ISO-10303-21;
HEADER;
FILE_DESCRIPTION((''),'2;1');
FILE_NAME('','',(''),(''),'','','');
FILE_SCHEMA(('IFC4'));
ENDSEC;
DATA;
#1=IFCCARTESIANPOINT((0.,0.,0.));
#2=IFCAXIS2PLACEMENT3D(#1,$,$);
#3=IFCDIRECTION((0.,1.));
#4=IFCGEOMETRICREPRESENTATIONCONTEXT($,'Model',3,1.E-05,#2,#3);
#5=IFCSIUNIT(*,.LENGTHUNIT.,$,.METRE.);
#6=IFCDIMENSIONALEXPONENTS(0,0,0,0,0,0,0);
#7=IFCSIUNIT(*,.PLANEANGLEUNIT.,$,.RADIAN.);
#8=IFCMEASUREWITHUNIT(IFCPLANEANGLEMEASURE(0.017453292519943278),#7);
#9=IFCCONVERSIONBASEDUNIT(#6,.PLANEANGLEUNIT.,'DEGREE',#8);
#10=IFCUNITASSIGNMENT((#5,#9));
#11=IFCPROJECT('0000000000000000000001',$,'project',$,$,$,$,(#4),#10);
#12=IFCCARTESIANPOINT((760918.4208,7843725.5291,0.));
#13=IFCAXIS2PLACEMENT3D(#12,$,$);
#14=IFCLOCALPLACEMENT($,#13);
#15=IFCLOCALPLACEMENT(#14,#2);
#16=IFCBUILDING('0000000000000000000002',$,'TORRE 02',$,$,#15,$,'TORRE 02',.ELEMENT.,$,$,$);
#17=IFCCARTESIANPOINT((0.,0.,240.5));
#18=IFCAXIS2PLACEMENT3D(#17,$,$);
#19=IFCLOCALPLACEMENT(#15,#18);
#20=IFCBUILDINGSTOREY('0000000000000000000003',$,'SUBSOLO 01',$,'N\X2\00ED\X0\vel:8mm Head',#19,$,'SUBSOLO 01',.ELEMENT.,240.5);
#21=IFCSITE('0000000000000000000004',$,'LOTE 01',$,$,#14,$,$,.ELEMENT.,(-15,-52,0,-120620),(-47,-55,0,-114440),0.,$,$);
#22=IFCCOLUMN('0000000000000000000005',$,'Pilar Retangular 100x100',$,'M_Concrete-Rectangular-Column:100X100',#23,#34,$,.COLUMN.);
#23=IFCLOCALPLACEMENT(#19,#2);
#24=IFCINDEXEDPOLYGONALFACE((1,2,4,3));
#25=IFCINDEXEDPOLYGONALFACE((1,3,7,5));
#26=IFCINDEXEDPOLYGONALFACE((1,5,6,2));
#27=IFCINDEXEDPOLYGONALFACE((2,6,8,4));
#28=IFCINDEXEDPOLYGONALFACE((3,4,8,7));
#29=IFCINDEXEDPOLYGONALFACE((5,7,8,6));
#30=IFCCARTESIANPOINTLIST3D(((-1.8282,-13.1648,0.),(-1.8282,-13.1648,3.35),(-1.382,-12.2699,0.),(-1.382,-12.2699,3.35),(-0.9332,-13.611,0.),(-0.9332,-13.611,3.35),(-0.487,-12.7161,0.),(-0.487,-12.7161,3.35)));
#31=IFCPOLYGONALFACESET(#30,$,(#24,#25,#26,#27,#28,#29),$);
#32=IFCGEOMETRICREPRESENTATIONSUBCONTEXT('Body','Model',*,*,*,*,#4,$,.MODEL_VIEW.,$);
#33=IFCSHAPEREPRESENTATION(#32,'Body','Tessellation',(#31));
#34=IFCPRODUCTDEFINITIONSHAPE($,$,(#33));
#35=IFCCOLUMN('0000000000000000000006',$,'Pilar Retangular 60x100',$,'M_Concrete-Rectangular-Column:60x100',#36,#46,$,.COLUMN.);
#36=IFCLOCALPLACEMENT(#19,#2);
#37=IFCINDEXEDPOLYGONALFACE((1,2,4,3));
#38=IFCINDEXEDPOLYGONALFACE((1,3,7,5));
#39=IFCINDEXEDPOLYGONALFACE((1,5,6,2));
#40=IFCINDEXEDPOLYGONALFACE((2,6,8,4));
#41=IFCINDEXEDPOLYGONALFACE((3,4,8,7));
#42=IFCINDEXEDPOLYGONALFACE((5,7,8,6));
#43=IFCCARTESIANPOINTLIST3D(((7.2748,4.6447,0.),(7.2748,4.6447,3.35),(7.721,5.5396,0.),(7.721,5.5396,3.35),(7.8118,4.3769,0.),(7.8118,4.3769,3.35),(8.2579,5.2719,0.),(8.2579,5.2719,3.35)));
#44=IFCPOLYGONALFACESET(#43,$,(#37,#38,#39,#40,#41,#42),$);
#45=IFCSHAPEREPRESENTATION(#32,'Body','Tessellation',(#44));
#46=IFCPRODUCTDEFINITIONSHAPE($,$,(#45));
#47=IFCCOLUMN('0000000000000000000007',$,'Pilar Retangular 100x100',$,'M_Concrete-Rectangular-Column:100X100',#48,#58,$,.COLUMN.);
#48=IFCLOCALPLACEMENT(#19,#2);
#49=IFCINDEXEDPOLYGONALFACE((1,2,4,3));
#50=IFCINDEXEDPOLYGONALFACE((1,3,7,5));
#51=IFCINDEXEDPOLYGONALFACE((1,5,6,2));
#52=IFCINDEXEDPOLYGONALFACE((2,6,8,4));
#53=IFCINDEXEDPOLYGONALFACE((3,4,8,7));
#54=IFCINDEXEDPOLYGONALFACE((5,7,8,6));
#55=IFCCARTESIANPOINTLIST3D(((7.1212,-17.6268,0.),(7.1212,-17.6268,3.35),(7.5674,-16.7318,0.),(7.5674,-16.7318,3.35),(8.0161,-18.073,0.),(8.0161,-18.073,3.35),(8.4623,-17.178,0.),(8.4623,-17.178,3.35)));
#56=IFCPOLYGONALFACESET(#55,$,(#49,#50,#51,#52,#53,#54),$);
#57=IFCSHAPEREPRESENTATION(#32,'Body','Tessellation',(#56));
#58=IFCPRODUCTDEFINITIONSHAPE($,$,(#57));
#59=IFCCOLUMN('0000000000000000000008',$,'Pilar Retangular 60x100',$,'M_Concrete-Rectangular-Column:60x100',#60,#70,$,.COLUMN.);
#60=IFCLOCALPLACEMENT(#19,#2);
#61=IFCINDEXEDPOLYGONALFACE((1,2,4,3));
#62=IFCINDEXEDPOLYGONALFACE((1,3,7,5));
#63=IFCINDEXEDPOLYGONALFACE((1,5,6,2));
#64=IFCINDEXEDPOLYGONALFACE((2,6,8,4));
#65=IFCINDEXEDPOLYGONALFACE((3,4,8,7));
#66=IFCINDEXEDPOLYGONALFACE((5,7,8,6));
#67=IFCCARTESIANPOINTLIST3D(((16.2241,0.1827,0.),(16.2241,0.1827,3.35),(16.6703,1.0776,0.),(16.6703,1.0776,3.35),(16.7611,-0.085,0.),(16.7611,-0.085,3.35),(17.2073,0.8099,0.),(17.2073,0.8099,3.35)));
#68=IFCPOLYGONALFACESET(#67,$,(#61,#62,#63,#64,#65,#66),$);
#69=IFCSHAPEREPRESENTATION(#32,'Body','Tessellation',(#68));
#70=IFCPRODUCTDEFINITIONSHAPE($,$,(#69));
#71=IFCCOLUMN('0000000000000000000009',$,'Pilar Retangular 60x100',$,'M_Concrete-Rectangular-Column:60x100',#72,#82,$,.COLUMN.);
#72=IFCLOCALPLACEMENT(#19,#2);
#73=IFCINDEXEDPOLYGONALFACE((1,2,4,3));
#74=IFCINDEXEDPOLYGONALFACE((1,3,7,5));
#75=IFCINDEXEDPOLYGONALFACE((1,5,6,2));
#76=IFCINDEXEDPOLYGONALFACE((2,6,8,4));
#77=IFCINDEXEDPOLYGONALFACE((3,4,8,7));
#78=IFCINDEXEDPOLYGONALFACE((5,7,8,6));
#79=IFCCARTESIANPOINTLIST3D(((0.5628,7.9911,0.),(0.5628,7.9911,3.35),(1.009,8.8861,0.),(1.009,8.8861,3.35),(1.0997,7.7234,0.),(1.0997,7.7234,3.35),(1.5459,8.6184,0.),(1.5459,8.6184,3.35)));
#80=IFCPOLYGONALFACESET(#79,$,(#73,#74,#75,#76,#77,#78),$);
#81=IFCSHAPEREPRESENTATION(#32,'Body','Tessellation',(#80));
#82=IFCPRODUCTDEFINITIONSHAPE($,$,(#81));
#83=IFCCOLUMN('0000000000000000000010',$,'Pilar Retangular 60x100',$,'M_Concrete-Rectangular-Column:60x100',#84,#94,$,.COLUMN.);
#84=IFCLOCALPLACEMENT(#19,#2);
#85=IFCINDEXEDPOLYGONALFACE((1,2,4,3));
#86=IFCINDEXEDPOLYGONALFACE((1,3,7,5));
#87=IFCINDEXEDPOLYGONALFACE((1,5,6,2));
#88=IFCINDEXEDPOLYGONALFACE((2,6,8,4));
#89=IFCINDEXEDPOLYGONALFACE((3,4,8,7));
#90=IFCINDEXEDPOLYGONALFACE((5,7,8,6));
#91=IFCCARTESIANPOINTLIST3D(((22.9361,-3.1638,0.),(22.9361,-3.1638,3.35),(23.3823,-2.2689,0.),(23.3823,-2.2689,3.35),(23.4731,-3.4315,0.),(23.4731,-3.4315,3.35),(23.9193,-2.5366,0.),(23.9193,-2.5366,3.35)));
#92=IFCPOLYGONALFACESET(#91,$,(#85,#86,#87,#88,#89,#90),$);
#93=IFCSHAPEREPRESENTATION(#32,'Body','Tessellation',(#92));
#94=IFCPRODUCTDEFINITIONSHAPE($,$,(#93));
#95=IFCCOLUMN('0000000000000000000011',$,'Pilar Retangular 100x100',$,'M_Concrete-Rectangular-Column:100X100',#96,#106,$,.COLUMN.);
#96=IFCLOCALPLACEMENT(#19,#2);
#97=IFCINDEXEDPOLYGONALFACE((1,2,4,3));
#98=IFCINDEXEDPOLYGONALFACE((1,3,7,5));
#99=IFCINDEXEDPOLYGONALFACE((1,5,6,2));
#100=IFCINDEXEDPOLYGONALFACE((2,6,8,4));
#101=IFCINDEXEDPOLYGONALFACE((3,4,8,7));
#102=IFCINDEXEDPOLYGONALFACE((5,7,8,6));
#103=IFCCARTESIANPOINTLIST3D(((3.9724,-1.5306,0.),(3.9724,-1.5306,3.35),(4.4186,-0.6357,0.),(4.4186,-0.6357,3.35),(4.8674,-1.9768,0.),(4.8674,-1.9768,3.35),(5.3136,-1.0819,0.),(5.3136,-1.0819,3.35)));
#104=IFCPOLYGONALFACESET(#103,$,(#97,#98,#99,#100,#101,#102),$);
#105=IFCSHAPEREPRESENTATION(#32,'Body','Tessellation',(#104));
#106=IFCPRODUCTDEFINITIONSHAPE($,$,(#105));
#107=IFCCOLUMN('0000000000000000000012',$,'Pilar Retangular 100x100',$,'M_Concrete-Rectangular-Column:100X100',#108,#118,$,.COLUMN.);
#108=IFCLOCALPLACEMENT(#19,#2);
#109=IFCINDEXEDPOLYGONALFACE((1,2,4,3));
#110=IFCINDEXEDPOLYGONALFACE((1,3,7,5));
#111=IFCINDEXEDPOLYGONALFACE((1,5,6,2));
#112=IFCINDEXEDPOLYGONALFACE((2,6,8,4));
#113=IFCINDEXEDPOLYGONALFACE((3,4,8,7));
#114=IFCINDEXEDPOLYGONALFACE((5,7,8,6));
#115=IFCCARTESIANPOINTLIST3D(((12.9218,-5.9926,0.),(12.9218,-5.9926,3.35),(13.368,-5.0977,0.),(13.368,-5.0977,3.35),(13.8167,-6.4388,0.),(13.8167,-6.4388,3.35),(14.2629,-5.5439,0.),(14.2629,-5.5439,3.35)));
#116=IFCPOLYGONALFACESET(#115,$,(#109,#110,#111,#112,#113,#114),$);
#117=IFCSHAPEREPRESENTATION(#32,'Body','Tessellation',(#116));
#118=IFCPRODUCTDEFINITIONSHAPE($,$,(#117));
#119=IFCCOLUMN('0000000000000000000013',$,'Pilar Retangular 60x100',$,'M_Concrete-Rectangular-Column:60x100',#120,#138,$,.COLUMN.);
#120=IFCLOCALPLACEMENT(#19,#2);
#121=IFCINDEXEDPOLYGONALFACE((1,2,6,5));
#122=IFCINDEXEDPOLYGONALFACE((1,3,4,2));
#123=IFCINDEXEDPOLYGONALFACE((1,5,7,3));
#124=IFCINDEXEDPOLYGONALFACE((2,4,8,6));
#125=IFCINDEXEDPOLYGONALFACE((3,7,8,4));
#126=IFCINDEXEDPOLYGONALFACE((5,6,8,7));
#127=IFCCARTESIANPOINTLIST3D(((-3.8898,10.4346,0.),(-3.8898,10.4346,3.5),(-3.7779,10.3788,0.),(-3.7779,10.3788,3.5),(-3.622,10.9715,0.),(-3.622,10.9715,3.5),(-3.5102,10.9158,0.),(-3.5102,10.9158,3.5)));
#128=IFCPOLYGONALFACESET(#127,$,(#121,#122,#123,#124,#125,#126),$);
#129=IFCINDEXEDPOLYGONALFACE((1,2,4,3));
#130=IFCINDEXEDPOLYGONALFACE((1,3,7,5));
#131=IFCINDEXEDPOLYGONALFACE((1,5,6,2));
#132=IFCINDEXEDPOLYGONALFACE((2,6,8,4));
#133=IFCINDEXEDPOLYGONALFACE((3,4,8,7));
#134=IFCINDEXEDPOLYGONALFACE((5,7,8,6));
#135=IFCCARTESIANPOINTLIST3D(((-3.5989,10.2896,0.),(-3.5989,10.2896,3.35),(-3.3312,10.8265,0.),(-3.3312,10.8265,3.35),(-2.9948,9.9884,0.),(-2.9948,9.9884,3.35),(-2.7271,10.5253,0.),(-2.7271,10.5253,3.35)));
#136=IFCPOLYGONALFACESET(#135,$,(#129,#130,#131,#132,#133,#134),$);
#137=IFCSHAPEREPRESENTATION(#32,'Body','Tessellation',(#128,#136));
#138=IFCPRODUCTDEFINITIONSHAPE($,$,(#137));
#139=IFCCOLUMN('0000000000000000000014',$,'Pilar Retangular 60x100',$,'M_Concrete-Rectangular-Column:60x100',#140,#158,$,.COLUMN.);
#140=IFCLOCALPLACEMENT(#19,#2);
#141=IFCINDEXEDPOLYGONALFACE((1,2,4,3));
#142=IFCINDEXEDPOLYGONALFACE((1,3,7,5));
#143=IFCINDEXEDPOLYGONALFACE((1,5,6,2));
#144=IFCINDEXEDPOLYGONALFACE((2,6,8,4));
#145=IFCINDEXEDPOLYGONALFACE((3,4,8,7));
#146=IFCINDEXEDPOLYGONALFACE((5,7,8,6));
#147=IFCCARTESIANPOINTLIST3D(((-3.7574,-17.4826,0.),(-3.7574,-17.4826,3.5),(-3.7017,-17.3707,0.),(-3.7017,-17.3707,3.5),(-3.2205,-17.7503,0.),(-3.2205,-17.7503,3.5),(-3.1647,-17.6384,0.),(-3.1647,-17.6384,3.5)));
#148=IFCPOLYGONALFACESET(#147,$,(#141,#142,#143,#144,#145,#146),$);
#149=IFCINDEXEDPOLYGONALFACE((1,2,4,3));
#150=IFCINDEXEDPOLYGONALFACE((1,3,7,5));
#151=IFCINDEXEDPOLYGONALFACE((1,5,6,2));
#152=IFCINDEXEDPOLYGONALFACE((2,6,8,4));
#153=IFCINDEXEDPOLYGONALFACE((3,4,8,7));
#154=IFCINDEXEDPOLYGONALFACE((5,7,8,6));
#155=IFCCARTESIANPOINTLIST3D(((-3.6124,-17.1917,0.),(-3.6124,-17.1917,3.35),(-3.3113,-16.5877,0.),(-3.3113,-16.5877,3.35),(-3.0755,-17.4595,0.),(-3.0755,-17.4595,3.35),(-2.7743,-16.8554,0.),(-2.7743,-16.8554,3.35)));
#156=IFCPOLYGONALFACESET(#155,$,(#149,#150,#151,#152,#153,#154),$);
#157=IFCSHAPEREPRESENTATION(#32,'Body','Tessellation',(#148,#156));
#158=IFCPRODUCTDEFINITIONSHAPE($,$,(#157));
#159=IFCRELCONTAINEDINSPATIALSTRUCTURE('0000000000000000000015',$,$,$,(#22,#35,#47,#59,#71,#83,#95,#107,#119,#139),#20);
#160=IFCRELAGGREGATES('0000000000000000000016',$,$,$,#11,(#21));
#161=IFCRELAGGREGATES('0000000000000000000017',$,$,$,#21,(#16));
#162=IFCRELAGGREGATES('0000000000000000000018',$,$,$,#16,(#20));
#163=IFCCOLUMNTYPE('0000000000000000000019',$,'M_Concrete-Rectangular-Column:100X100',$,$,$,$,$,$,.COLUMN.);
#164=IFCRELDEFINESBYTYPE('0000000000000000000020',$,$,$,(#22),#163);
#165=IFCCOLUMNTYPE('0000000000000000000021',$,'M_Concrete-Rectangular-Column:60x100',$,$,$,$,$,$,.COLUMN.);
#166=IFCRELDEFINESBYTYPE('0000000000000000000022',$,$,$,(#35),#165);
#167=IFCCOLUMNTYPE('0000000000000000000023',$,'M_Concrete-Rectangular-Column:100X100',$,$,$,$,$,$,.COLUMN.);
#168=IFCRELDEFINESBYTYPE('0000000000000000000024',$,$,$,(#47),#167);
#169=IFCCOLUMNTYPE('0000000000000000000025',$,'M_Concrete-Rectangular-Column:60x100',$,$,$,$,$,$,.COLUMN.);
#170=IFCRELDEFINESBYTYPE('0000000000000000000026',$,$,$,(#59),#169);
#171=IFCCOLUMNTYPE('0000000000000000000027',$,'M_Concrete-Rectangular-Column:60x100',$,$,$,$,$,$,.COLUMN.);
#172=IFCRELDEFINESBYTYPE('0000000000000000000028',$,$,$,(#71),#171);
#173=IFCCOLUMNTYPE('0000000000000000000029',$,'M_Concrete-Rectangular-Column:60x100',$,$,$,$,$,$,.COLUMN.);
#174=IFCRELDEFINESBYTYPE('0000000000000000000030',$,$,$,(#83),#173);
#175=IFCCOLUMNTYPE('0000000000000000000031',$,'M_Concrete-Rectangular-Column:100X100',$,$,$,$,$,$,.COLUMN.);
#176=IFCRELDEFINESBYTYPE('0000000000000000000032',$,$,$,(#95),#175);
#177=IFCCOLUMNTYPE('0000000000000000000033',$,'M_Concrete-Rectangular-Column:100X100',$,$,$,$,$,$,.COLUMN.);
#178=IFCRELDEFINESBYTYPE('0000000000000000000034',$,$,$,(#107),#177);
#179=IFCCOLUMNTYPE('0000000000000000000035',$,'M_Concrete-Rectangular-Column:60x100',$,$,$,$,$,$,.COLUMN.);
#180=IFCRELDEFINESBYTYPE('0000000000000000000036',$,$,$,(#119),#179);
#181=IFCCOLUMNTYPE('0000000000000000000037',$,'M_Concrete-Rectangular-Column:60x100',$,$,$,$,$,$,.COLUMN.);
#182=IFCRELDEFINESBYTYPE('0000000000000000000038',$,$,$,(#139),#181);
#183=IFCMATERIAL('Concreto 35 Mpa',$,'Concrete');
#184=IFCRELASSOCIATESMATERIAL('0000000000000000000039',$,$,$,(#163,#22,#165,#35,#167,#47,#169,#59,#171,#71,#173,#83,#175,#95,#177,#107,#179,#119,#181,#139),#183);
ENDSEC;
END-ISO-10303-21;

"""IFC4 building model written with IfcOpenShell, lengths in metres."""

from ifc_helpers import new_model, entity, si_unit, converted_unit, direction, frame, origin, place, context, subcontext, project, spatial, indexed_curve, outline, extrude, source, transform, mapped, material, type_object, type_shapes, element, save


model = new_model("IFC4")

# Units and contexts
model_context = context("Model", 3, precision=1e-05, world=origin(), true_north=direction((0.0, 1.0)))
body_context = subcontext(model_context, "Body", "Model", "MODEL_VIEW")
ifc_project = project(units=[si_unit("LENGTHUNIT", "METRE"), converted_unit("PLANEANGLEUNIT", "DEGREE", entity("IfcPlaneAngleMeasure", 0.017453292519943278), si_unit("PLANEANGLEUNIT", "RADIAN"), dimensions=[0, 0, 0, 0, 0, 0, 0])], contexts=[model_context])

# Site, building, storey
site_placement = place(None, frame((760918.4208, 7843725.5291, 0.0)))
site = spatial("IfcSite", under=ifc_project, at=site_placement, Name="LOTE 01", CompositionType="ELEMENT", RefLatitude=(-15, -52, 0, -120620), RefLongitude=(-47, -55, 0, -114440), RefElevation=0.0)
building_placement = place(site_placement, origin())
building = spatial("IfcBuilding", under=site, at=building_placement, Name="TORRE 02", LongName="TORRE 02", CompositionType="ELEMENT")
storey_placement = place(building_placement, frame((0.0, 0.0, 240.5)))
storey = spatial("IfcBuildingStorey", under=building, at=storey_placement, Name="SUBSOLO 01", ObjectType="Nível:8mm Head", LongName="SUBSOLO 01", CompositionType="ELEMENT", Elevation=240.5)

# Columns
ifc_material = material(Name="Concreto 35 Mpa", Category="Concrete")
column_type_1 = type_object("IfcColumnType", Name="M_Concrete-Rectangular-Column:100X100", PredefinedType="COLUMN", material=ifc_material)
shared_shape_1 = source(origin(), body_context, "Body", "SweptSolid", [
    extrude(outline(indexed_curve([(-0.5, -0.5), (0.5, -0.5), (0.5, 0.5), (-0.5, 0.5), (-0.5, -0.5)], self_intersect=False)), frame((-1.1576, -12.9404, 240.5), z_axis=(0.0, 0.0, 1.0), x_axis=(-0.894934, 0.446198, 0.0)), (0.0, 0.0, 1.0), 3.35),
])
type_shapes(column_type_1, [shared_shape_1])
column_1_placement = place(storey_placement, frame((0.0, 0.0, -240.5)))
element("IfcColumn", 1, at=column_1_placement, inside=storey, type_object=column_type_1, material=ifc_material, Name="Pilar Retangular 100x100", ObjectType="M_Concrete-Rectangular-Column:100X100", PredefinedType="COLUMN", context=body_context, shape_type="MappedRepresentation", body=[
    mapped(shared_shape_1, transform((0.0, 0.0, 0.0), scale=1.0)),
])
column_type_2 = type_object("IfcColumnType", Name="M_Concrete-Rectangular-Column:60x100", PredefinedType="COLUMN", material=ifc_material)
shared_shape_2 = source(origin(), body_context, "Body", "SweptSolid", [
    extrude(outline(indexed_curve([(-1.675, -0.3), (1.675, -0.3), (1.675, 0.3), (-1.675, 0.3), (-1.675, -0.3)], self_intersect=False)), frame((7.5433, 4.5108, 242.175), z_axis=(0.446198, 0.894934, 0.0), x_axis=(0.0, 0.0, 1.0)), (0.0, 0.0, 1.0), 1.0),
])
type_shapes(column_type_2, [shared_shape_2])
column_2_placement = place(storey_placement, frame((0.0, 0.0, -240.5)))
element("IfcColumn", 2, at=column_2_placement, inside=storey, type_object=column_type_2, material=ifc_material, Name="Pilar Retangular 60x100", ObjectType="M_Concrete-Rectangular-Column:60x100", PredefinedType="COLUMN", context=body_context, shape_type="MappedRepresentation", body=[
    mapped(shared_shape_2, transform((0.0, 0.0, 0.0), scale=1.0)),
])
column_type_3 = type_object("IfcColumnType", Name="M_Concrete-Rectangular-Column:100X100", PredefinedType="COLUMN", material=ifc_material)
shared_shape_3 = source(origin(), body_context, "Body", "SweptSolid", [
    extrude(outline(indexed_curve([(-0.5, -0.5), (0.5, -0.5), (0.5, 0.5), (-0.5, 0.5), (-0.5, -0.5)], self_intersect=False)), frame((7.7918, -17.4024, 240.5), z_axis=(0.0, 0.0, 1.0), x_axis=(-0.894934, 0.446198, 0.0)), (0.0, 0.0, 1.0), 3.35),
])
type_shapes(column_type_3, [shared_shape_3])
column_3_placement = place(storey_placement, frame((0.0, 0.0, -240.5)))
element("IfcColumn", 3, at=column_3_placement, inside=storey, type_object=column_type_3, material=ifc_material, Name="Pilar Retangular 100x100", ObjectType="M_Concrete-Rectangular-Column:100X100", PredefinedType="COLUMN", context=body_context, shape_type="MappedRepresentation", body=[
    mapped(shared_shape_3, transform((0.0, 0.0, 0.0), scale=1.0)),
])
column_type_4 = type_object("IfcColumnType", Name="M_Concrete-Rectangular-Column:60x100", PredefinedType="COLUMN", material=ifc_material)
shared_shape_4 = source(origin(), body_context, "Body", "SweptSolid", [
    extrude(outline(indexed_curve([(-1.675, -0.3), (1.675, -0.3), (1.675, 0.3), (-1.675, 0.3), (-1.675, -0.3)], self_intersect=False)), frame((16.4926, 0.0488, 242.175), z_axis=(0.446198, 0.894934, 0.0), x_axis=(0.0, 0.0, 1.0)), (0.0, 0.0, 1.0), 1.0),
])
type_shapes(column_type_4, [shared_shape_4])
column_4_placement = place(storey_placement, frame((0.0, 0.0, -240.5)))
element("IfcColumn", 4, at=column_4_placement, inside=storey, type_object=column_type_4, material=ifc_material, Name="Pilar Retangular 60x100", ObjectType="M_Concrete-Rectangular-Column:60x100", PredefinedType="COLUMN", context=body_context, shape_type="MappedRepresentation", body=[
    mapped(shared_shape_4, transform((0.0, 0.0, 0.0), scale=1.0)),
])
column_type_5 = type_object("IfcColumnType", Name="M_Concrete-Rectangular-Column:60x100", PredefinedType="COLUMN", material=ifc_material)
shared_shape_5 = source(origin(), body_context, "Body", "SweptSolid", [
    extrude(outline(indexed_curve([(-1.675, -0.3), (1.675, -0.3), (1.675, 0.3), (-1.675, 0.3), (-1.675, -0.3)], self_intersect=False)), frame((0.8313, 7.8573, 242.175), z_axis=(0.446198, 0.894934, 0.0), x_axis=(0.0, 0.0, 1.0)), (0.0, 0.0, 1.0), 1.0),
])
type_shapes(column_type_5, [shared_shape_5])
column_5_placement = place(storey_placement, frame((0.0, 0.0, -240.5)))
element("IfcColumn", 5, at=column_5_placement, inside=storey, type_object=column_type_5, material=ifc_material, Name="Pilar Retangular 60x100", ObjectType="M_Concrete-Rectangular-Column:60x100", PredefinedType="COLUMN", context=body_context, shape_type="MappedRepresentation", body=[
    mapped(shared_shape_5, transform((0.0, 0.0, 0.0), scale=1.0)),
])
column_type_6 = type_object("IfcColumnType", Name="M_Concrete-Rectangular-Column:60x100", PredefinedType="COLUMN", material=ifc_material)
shared_shape_6 = source(origin(), body_context, "Body", "SweptSolid", [
    extrude(outline(indexed_curve([(-1.675, -0.3), (1.675, -0.3), (1.675, 0.3), (-1.675, 0.3), (-1.675, -0.3)], self_intersect=False)), frame((23.2046, -3.2977, 242.175), z_axis=(0.446198, 0.894934, 0.0), x_axis=(0.0, 0.0, 1.0)), (0.0, 0.0, 1.0), 1.0),
])
type_shapes(column_type_6, [shared_shape_6])
column_6_placement = place(storey_placement, frame((0.0, 0.0, -240.5)))
element("IfcColumn", 6, at=column_6_placement, inside=storey, type_object=column_type_6, material=ifc_material, Name="Pilar Retangular 60x100", ObjectType="M_Concrete-Rectangular-Column:60x100", PredefinedType="COLUMN", context=body_context, shape_type="MappedRepresentation", body=[
    mapped(shared_shape_6, transform((0.0, 0.0, 0.0), scale=1.0)),
])
column_type_7 = type_object("IfcColumnType", Name="M_Concrete-Rectangular-Column:100X100", PredefinedType="COLUMN", material=ifc_material)
shared_shape_7 = source(origin(), body_context, "Body", "SweptSolid", [
    extrude(outline(indexed_curve([(-0.5, -0.5), (0.5, -0.5), (0.5, 0.5), (-0.5, 0.5), (-0.5, -0.5)], self_intersect=False)), frame((4.643, -1.3063, 240.5), z_axis=(0.0, 0.0, 1.0), x_axis=(-0.894934, 0.446198, 0.0)), (0.0, 0.0, 1.0), 3.35),
])
type_shapes(column_type_7, [shared_shape_7])
column_7_placement = place(storey_placement, frame((0.0, 0.0, -240.5)))
element("IfcColumn", 7, at=column_7_placement, inside=storey, type_object=column_type_7, material=ifc_material, Name="Pilar Retangular 100x100", ObjectType="M_Concrete-Rectangular-Column:100X100", PredefinedType="COLUMN", context=body_context, shape_type="MappedRepresentation", body=[
    mapped(shared_shape_7, transform((0.0, 0.0, 0.0), scale=1.0)),
])
column_type_8 = type_object("IfcColumnType", Name="M_Concrete-Rectangular-Column:100X100", PredefinedType="COLUMN", material=ifc_material)
shared_shape_8 = source(origin(), body_context, "Body", "SweptSolid", [
    extrude(outline(indexed_curve([(-0.5, -0.5), (0.5, -0.5), (0.5, 0.5), (-0.5, 0.5), (-0.5, -0.5)], self_intersect=False)), frame((13.5923, -5.7683, 240.5), z_axis=(0.0, 0.0, 1.0), x_axis=(-0.894934, 0.446198, 0.0)), (0.0, 0.0, 1.0), 3.35),
])
type_shapes(column_type_8, [shared_shape_8])
column_8_placement = place(storey_placement, frame((0.0, 0.0, -240.5)))
element("IfcColumn", 8, at=column_8_placement, inside=storey, type_object=column_type_8, material=ifc_material, Name="Pilar Retangular 100x100", ObjectType="M_Concrete-Rectangular-Column:100X100", PredefinedType="COLUMN", context=body_context, shape_type="MappedRepresentation", body=[
    mapped(shared_shape_8, transform((0.0, 0.0, 0.0), scale=1.0)),
])
column_type_9 = type_object("IfcColumnType", Name="M_Concrete-Rectangular-Column:60x100", PredefinedType="COLUMN", material=ifc_material)
shared_shape_9 = source(origin(), body_context, "Body", "SweptSolid", [
    extrude(outline(indexed_curve([(-0.0625, -0.3), (0.0625, -0.3), (0.0625, 0.3), (-0.0625, 0.3), (-0.0625, -0.3)], self_intersect=False)), frame((-3.7, 10.6752, 240.5), z_axis=(0.0, 0.0, 1.0), x_axis=(0.894934, -0.446198, 0.0)), (0.0, 0.0, 1.0), 3.5),
    extrude(outline(indexed_curve([(-0.3375, -0.3), (0.3375, -0.3), (0.3375, 0.3), (-0.3375, 0.3), (-0.3375, -0.3)], self_intersect=False)), frame((-3.163, 10.4075, 240.5), z_axis=(0.0, 0.0, 1.0), x_axis=(-0.894934, 0.446198, 0.0)), (0.0, 0.0, 1.0), 3.35),
])
type_shapes(column_type_9, [shared_shape_9])
column_9_placement = place(storey_placement, frame((0.0, 0.0, -240.5)))
element("IfcColumn", 9, at=column_9_placement, inside=storey, type_object=column_type_9, material=ifc_material, Name="Pilar Retangular 60x100", ObjectType="M_Concrete-Rectangular-Column:60x100", PredefinedType="COLUMN", context=body_context, shape_type="MappedRepresentation", body=[
    mapped(shared_shape_9, transform((0.0, 0.0, 0.0), scale=1.0)),
])
column_type_10 = type_object("IfcColumnType", Name="M_Concrete-Rectangular-Column:60x100", PredefinedType="COLUMN", material=ifc_material)
shared_shape_10 = source(origin(), body_context, "Body", "SweptSolid", [
    extrude(outline(indexed_curve([(-0.0625, -0.3), (0.0625, -0.3), (0.0625, 0.3), (-0.0625, 0.3), (-0.0625, -0.3)], self_intersect=False)), frame((-3.4611, -17.5605, 240.5), z_axis=(0.0, 0.0, 1.0), x_axis=(0.446198, 0.894934, 0.0)), (0.0, 0.0, 1.0), 3.5),
    extrude(outline(indexed_curve([(-1.675, -0.3375), (1.675, -0.3375), (1.675, 0.3375), (-1.675, 0.3375), (-1.675, -0.3375)], self_intersect=False)), frame((-3.4618, -16.8897, 242.175), z_axis=(0.894934, -0.446198, 0.0), x_axis=(0.0, 0.0, 1.0)), (0.0, 0.0, 1.0), 0.6),
])
type_shapes(column_type_10, [shared_shape_10])
column_10_placement = place(storey_placement, frame((0.0, 0.0, -240.5)))
element("IfcColumn", 10, at=column_10_placement, inside=storey, type_object=column_type_10, material=ifc_material, Name="Pilar Retangular 60x100", ObjectType="M_Concrete-Rectangular-Column:60x100", PredefinedType="COLUMN", context=body_context, shape_type="MappedRepresentation", body=[
    mapped(shared_shape_10, transform((0.0, 0.0, 0.0), scale=1.0)),
])

save(model, "model.ifc")
